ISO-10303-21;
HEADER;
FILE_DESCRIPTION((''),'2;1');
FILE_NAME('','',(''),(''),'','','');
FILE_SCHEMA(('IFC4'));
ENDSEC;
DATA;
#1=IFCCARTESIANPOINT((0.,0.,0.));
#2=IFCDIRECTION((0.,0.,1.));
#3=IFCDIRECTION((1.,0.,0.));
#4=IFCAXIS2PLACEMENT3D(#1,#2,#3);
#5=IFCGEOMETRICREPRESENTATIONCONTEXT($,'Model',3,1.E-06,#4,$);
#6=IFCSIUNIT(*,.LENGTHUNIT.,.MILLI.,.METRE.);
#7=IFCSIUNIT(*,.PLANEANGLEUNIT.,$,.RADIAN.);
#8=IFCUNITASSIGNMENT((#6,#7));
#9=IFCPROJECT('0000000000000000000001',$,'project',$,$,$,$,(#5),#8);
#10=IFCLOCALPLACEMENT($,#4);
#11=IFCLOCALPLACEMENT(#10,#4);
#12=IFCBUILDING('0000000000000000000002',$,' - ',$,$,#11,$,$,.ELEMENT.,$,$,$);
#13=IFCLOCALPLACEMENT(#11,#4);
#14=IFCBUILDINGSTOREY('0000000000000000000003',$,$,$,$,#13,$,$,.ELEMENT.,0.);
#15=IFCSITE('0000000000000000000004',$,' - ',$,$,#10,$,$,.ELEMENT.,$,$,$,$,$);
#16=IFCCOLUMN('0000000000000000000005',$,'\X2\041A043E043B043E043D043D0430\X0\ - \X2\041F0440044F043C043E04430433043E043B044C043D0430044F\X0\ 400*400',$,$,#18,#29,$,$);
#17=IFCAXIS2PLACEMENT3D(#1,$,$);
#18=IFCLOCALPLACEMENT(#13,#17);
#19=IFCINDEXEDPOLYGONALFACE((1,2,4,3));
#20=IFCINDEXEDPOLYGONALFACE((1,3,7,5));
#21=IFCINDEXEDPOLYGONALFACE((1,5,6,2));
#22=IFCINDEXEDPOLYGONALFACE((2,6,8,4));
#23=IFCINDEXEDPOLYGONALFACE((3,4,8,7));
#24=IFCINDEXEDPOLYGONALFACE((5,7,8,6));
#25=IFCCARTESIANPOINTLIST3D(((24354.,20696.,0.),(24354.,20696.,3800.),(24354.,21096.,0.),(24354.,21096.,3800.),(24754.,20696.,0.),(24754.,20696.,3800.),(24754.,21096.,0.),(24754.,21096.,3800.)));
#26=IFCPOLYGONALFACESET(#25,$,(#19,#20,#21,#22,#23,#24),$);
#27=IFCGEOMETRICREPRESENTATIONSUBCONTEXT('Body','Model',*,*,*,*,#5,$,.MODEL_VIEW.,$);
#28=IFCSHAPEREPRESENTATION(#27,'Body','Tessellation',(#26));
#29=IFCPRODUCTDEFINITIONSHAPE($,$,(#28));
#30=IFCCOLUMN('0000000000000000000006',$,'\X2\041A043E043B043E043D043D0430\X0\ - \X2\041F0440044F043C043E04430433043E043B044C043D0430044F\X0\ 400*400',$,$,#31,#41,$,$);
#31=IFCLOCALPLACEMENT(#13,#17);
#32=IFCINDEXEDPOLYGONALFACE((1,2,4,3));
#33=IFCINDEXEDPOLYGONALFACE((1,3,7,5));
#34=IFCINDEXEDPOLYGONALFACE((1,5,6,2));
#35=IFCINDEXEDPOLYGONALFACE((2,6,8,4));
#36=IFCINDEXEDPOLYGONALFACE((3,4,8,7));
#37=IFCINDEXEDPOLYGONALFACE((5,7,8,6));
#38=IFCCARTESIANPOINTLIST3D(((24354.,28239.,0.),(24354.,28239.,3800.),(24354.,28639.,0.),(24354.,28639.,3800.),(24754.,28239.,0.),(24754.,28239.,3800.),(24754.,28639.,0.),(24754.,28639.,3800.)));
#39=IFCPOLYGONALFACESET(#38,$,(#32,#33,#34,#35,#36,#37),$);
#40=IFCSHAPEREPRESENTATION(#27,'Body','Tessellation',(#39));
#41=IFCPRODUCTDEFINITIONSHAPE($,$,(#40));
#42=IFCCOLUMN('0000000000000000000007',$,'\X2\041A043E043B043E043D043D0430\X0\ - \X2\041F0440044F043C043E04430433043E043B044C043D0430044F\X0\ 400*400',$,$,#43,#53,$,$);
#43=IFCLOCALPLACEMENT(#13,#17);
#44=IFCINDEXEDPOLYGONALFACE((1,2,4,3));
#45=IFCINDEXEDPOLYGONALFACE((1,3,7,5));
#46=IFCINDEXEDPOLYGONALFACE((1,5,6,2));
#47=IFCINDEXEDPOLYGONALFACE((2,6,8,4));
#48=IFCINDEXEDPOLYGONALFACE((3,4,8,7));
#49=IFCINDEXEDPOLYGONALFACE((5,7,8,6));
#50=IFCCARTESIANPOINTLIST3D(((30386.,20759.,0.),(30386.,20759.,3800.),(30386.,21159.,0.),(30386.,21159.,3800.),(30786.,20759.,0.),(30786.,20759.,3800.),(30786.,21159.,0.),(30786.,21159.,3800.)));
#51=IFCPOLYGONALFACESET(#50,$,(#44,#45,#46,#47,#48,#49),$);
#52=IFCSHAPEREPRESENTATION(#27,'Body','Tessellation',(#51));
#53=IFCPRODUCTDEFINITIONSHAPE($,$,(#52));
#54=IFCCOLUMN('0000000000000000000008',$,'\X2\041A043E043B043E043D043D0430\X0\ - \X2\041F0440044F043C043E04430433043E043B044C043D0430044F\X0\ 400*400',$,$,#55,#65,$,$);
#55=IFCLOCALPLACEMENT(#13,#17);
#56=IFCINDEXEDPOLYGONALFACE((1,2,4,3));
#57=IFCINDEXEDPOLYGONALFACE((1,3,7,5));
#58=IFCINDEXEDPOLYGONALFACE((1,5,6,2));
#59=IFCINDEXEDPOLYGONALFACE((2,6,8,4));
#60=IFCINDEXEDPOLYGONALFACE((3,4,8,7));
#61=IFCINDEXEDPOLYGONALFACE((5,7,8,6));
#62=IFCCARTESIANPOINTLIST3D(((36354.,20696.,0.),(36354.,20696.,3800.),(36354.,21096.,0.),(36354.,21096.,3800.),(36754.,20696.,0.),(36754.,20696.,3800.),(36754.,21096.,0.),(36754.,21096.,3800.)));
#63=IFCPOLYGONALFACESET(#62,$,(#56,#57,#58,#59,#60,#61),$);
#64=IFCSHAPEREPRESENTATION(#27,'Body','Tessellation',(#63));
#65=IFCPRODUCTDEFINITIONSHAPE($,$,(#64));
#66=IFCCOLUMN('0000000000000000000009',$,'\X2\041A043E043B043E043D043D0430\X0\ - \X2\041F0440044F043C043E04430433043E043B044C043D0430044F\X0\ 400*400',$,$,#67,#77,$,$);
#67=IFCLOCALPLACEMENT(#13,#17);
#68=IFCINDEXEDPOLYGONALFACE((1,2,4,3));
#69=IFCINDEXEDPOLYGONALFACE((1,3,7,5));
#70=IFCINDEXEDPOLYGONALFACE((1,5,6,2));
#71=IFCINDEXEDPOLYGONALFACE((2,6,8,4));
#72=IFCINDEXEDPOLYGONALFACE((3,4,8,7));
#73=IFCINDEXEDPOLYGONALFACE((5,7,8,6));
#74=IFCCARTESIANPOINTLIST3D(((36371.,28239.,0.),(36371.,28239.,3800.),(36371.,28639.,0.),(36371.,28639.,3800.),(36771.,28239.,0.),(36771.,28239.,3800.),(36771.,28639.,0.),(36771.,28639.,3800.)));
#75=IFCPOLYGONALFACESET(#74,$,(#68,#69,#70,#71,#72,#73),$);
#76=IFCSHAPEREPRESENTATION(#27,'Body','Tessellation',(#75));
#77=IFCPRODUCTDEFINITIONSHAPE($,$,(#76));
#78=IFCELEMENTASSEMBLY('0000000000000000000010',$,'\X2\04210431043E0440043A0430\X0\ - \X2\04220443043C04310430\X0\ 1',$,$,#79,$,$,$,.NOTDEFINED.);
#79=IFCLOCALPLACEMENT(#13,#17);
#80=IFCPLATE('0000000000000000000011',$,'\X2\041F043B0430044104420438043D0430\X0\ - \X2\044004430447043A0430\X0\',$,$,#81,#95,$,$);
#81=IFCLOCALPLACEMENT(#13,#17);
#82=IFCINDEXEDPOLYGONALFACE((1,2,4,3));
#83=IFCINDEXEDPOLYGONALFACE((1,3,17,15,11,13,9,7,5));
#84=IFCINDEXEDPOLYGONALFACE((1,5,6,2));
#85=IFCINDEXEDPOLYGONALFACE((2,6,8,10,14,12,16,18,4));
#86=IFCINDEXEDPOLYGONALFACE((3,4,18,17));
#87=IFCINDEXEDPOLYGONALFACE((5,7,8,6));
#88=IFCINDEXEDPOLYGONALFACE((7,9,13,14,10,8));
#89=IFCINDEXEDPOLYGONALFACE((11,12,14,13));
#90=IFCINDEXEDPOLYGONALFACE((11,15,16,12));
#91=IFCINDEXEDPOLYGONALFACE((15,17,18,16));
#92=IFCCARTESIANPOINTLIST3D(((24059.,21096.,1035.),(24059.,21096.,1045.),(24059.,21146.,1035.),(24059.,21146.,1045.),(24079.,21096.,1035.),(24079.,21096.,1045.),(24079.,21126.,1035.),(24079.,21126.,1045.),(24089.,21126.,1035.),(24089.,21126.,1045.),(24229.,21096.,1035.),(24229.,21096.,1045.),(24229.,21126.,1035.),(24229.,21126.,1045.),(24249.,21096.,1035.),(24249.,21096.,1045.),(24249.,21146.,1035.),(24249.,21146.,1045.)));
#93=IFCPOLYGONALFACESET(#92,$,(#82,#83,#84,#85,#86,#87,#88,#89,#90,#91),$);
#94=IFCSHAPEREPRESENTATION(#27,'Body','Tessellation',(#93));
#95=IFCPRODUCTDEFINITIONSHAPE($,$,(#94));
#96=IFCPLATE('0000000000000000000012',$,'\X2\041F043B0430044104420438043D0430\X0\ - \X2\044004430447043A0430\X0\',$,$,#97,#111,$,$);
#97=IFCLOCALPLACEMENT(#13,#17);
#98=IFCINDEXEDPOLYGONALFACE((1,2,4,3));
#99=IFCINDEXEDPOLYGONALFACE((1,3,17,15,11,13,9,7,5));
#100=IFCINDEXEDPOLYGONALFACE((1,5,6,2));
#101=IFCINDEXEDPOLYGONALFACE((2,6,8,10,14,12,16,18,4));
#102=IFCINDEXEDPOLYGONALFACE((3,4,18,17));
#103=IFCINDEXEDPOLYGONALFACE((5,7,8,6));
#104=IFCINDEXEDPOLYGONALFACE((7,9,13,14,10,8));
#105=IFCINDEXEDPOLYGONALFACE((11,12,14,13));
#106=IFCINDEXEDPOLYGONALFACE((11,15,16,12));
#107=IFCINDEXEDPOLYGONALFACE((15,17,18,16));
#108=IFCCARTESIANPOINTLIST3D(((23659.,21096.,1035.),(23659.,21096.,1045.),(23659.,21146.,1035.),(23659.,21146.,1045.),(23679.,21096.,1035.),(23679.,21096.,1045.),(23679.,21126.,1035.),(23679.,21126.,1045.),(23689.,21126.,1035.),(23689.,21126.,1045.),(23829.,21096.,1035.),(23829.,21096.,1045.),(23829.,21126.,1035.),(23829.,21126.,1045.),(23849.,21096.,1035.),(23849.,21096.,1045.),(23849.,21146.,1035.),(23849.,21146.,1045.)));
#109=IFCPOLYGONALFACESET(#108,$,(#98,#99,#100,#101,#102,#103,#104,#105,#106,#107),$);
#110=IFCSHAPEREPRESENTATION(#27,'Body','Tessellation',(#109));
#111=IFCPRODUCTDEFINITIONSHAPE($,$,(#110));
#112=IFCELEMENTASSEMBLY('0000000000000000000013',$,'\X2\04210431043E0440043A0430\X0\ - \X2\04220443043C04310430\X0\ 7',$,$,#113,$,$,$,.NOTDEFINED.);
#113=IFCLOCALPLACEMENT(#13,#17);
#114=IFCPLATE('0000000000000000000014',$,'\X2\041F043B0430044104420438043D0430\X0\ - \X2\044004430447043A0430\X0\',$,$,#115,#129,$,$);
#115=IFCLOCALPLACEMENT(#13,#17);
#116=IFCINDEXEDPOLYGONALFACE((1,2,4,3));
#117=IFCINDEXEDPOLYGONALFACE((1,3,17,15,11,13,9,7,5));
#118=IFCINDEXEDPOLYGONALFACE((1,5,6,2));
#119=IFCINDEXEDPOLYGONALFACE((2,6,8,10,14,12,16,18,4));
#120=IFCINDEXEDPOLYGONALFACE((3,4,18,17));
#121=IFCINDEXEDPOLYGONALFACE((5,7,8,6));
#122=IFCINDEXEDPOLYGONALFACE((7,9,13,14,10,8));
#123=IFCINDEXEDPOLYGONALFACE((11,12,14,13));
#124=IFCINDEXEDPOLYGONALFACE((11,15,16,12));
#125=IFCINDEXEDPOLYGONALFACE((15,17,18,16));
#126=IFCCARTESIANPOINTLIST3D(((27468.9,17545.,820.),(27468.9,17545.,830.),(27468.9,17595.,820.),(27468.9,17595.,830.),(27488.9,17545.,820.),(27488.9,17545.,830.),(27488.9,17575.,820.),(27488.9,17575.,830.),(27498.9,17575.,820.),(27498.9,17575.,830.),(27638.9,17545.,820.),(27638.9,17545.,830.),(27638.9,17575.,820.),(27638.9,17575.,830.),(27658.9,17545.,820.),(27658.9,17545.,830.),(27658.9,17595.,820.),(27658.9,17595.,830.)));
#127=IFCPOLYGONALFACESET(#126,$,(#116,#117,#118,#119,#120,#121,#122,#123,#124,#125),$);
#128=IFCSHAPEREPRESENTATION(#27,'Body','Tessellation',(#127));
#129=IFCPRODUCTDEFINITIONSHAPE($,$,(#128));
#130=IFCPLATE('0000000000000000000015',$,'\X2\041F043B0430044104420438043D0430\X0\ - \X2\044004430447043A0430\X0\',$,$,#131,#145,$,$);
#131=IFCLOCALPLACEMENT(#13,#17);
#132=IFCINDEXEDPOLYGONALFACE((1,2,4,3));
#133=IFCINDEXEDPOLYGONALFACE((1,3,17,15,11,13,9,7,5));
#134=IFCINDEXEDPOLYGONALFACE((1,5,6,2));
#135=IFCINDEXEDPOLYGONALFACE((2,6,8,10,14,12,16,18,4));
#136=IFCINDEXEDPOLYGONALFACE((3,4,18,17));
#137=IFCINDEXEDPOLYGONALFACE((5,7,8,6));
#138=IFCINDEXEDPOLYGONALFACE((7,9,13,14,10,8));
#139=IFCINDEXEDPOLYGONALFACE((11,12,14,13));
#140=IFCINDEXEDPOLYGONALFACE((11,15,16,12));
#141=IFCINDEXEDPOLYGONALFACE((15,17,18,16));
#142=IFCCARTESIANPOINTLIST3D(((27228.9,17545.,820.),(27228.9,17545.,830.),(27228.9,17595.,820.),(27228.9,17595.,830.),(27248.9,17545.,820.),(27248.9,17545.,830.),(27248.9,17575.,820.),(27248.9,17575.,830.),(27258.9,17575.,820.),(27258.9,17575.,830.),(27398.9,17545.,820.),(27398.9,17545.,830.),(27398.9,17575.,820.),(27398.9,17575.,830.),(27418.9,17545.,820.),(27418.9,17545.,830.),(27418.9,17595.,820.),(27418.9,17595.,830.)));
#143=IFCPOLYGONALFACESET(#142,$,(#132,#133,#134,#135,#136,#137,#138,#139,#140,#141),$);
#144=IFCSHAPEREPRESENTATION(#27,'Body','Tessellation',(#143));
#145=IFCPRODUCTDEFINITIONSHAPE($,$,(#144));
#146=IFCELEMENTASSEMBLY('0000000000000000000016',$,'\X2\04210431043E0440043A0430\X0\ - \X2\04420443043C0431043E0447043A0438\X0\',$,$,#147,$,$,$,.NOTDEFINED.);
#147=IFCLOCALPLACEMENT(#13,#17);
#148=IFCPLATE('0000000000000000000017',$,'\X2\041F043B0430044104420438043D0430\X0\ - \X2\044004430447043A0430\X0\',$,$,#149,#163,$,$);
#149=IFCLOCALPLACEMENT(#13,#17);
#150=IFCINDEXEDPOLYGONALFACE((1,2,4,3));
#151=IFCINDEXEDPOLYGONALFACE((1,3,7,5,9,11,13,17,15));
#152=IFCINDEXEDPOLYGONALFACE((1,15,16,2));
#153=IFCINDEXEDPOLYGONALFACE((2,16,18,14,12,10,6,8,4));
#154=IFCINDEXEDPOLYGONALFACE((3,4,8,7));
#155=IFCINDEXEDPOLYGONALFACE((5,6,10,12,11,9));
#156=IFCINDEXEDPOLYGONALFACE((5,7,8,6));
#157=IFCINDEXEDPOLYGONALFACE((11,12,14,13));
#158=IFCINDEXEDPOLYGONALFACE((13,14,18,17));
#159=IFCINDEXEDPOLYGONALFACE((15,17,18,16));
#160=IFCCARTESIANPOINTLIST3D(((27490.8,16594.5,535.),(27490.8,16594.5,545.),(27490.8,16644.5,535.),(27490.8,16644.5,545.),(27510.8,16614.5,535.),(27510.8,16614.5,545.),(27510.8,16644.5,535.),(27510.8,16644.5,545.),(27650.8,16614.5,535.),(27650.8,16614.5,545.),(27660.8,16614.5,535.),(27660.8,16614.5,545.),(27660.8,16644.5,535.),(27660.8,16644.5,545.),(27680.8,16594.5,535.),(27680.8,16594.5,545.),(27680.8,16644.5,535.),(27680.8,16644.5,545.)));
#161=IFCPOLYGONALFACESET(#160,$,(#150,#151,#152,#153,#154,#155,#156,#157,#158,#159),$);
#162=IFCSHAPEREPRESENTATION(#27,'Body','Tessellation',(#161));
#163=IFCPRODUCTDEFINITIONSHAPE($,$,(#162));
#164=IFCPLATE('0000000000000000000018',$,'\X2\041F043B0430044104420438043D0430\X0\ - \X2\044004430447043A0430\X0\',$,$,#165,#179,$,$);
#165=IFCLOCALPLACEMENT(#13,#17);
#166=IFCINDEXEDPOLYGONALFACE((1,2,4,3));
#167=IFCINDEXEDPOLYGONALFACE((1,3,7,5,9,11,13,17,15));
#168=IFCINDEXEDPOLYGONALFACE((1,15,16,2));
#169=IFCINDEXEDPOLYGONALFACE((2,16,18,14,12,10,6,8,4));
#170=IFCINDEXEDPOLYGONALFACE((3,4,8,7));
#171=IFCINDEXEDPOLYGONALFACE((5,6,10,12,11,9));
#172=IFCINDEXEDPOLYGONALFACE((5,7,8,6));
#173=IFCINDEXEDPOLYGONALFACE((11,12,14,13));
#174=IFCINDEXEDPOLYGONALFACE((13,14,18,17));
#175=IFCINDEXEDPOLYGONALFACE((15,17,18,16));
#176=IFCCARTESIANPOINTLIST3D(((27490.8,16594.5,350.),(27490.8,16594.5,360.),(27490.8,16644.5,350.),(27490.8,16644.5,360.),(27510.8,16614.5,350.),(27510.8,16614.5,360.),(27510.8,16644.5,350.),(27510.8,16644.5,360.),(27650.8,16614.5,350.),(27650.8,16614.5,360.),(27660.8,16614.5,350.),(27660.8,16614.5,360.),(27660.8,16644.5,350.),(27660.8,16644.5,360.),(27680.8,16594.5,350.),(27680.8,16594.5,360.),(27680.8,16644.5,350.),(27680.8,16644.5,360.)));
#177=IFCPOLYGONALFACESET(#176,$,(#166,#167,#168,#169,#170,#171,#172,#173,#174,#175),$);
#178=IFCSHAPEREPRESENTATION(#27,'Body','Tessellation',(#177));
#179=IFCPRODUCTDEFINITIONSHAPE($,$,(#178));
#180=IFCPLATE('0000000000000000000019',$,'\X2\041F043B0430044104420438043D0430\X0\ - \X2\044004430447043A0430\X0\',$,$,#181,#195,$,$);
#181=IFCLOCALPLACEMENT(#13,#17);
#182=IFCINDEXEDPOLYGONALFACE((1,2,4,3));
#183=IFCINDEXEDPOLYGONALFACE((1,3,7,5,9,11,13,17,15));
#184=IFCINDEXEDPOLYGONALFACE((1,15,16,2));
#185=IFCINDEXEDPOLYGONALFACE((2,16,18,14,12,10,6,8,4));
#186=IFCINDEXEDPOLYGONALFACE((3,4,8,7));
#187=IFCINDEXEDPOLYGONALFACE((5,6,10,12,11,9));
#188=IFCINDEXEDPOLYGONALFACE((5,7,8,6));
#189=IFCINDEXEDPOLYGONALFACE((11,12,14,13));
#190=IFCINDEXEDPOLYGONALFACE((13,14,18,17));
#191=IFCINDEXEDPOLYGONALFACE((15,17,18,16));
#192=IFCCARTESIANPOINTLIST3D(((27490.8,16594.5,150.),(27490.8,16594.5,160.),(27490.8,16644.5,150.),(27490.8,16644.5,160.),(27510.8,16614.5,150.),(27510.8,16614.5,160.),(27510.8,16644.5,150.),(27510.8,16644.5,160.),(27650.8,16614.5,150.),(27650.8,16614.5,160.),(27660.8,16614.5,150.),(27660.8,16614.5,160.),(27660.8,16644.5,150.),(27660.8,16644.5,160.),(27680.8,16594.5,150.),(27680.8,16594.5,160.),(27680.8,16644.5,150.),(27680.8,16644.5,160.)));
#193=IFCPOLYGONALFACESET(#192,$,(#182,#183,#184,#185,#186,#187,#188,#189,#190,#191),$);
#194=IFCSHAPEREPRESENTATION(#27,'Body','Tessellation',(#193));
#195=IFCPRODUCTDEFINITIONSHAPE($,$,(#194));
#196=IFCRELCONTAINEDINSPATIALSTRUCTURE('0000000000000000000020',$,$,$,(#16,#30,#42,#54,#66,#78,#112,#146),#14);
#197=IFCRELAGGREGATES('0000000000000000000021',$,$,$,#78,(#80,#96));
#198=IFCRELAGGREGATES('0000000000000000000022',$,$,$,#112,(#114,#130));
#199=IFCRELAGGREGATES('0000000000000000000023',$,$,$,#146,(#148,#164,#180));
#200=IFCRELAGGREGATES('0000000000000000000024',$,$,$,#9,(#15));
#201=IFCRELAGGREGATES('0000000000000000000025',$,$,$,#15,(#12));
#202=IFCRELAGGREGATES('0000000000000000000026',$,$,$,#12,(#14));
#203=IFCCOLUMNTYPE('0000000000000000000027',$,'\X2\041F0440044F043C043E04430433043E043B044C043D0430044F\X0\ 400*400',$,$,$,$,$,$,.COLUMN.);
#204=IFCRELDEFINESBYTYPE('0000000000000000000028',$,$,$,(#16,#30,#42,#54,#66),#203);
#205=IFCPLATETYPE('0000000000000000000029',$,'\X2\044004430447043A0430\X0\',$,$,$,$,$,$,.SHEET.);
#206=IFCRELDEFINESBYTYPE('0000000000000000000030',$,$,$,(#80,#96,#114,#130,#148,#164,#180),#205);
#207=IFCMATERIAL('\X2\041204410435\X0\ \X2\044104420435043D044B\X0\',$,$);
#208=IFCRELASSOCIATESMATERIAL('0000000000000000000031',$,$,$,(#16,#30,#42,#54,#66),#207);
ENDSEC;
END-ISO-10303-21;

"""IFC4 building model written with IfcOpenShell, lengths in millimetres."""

from ifc_helpers import new_model, si_unit, frame, origin_with_axes, place, context, subcontext, project, spatial, line, indexed_curve, outline, extrude, source, transform, mapped, material, type_object, element, aggregate, save


model = new_model("IFC4")

# Units and contexts
model_context = context("Model", 3, precision=1e-06, world=origin_with_axes())
body_context = subcontext(model_context, "Body", "Model", "MODEL_VIEW")
ifc_project = project(units=[si_unit("LENGTHUNIT", "METRE", prefix="MILLI"), si_unit("PLANEANGLEUNIT", "RADIAN")], contexts=[model_context])

# Site, building, storey
site_placement = place(None, origin_with_axes())
site = spatial("IfcSite", under=ifc_project, at=site_placement, Name=" - ", CompositionType="ELEMENT")
building_placement = place(site_placement, origin_with_axes())
building = spatial("IfcBuilding", under=site, at=building_placement, Name=" - ", CompositionType="ELEMENT")
storey_placement = place(building_placement, origin_with_axes())
storey = spatial("IfcBuildingStorey", under=building, at=storey_placement, CompositionType="ELEMENT", Elevation=0.0)

# Columns
ifc_material = material(Name="Все стены")
column_type = type_object("IfcColumnType", Name="Прямоугольная 400*400", PredefinedType="COLUMN")
shared_shape_1 = source(origin_with_axes(), body_context, "Body", "SweptSolid", [
    extrude(outline(indexed_curve([(-200.0, -200.0), (200.0, -200.0), (200.0, 200.0), (-200.0, 200.0)], segments=[line(1, 2), line(2, 3), line(3, 4), line(4, 1)])), origin_with_axes(), (0.0, 0.0, 1.0), 3800.0),
])
for number, where, z_axis, x_axis, name in (
    (1, (24554.0, 20896.0, 0.0), (0.0, 0.0, 1.0), (1.0, 0.0, 0.0), "Колонна - Прямоугольная 400*400"),
    (2, (24554.0, 28439.0, 0.0), (0.0, 0.0, 1.0), (1.0, 0.0, 0.0), "Колонна - Прямоугольная 400*400"),
    (3, (30586.0, 20959.0, 0.0), (0.0, 0.0, 1.0), (1.0, 0.0, 0.0), "Колонна - Прямоугольная 400*400"),
    (4, (36554.0, 20896.0, 0.0), (0.0, 0.0, 1.0), (1.0, 0.0, 0.0), "Колонна - Прямоугольная 400*400"),
    (5, (36571.0, 28439.0, 0.0), (0.0, 0.0, 1.0), (1.0, 0.0, 0.0), "Колонна - Прямоугольная 400*400"),
):
    element("IfcColumn", number, at=place(storey_placement, frame(where, z_axis=z_axis, x_axis=x_axis)), inside=storey, type_object=column_type, material=ifc_material, Name=name, context=body_context, shape_type="MappedRepresentation", body=[
        mapped(shared_shape_1, transform((0.0, 0.0, 0.0), x_axis=(1.0, 0.0, 0.0), y_axis=(0.0, 1.0, 0.0), z_axis=(0.0, 0.0, 1.0), scale=1.0)),
    ])

# Element assemblies, plates
assembly_1_placement = place(storey_placement, frame((24354.0, 21081.0, 0.0), z_axis=(0.0, 0.0, 1.0), x_axis=(-1.0, 0.0, 0.0)))
assembly_1 = element("IfcElementAssembly", 6, at=assembly_1_placement, inside=storey, Name="Сборка - Тумба 1", PredefinedType="NOTDEFINED")
plate_type = type_object("IfcPlateType", Name="ручка", PredefinedType="SHEET")
shared_shape_2 = source(origin_with_axes(), body_context, "Body", "SweptSolid", [
    extrude(outline(indexed_curve([(-95.0, -25.0), (-75.0, -25.0), (-75.0, 5.0), (-65.0, 5.0), (75.0, 5.0), (75.0, -25.0), (95.0, -25.0), (95.0, 25.0), (-95.0, 25.0)], segments=[line(1, 2), line(2, 3), line(3, 4), line(4, 5), line(5, 6), line(6, 7), line(7, 8), line(8, 9), line(9, 1)])), origin_with_axes(), (0.0, 0.0, 1.0), 10.0),
])
plate_1_placement = place(assembly_1_placement, frame((200.0, -40.0, 1035.0), z_axis=(0.0, 0.0, 1.0), x_axis=(-1.0, 0.0, 0.0)))
plate_1 = element("IfcPlate", 7, at=plate_1_placement, type_object=plate_type, Name="Пластина - ручка", context=body_context, shape_type="MappedRepresentation", body=[
    mapped(shared_shape_2, transform((0.0, 0.0, 0.0), x_axis=(1.0, 0.0, 0.0), y_axis=(0.0, 1.0, 0.0), z_axis=(0.0, 0.0, 1.0), scale=1.0)),
])
plate_2_placement = place(assembly_1_placement, frame((600.0, -40.0, 1035.0), z_axis=(0.0, 0.0, 1.0), x_axis=(-1.0, 0.0, 0.0)))
plate_2 = element("IfcPlate", 8, at=plate_2_placement, type_object=plate_type, Name="Пластина - ручка", context=body_context, shape_type="MappedRepresentation", body=[
    mapped(shared_shape_2, transform((0.0, 0.0, 0.0), x_axis=(1.0, 0.0, 0.0), y_axis=(0.0, 1.0, 0.0), z_axis=(0.0, 0.0, 1.0), scale=1.0)),
])
aggregate(assembly_1, [plate_1, plate_2])
assembly_2_placement = place(storey_placement, frame((27443.9, 17330.0, 0.0), z_axis=(0.0, 0.0, 1.0), x_axis=(-1.0, 0.0, 0.0)))
assembly_2 = element("IfcElementAssembly", 9, at=assembly_2_placement, inside=storey, Name="Сборка - Тумба 7", PredefinedType="NOTDEFINED")
plate_3_placement = place(assembly_2_placement, frame((-120.0, -240.0, 820.0), z_axis=(0.0, 0.0, 1.0), x_axis=(-1.0, 0.0, 0.0)))
plate_3 = element("IfcPlate", 10, at=plate_3_placement, type_object=plate_type, Name="Пластина - ручка", context=body_context, shape_type="MappedRepresentation", body=[
    mapped(shared_shape_2, transform((0.0, 0.0, 0.0), x_axis=(1.0, 0.0, 0.0), y_axis=(0.0, 1.0, 0.0), z_axis=(0.0, 0.0, 1.0), scale=1.0)),
])
plate_4_placement = place(assembly_2_placement, frame((120.0, -240.0, 820.0), z_axis=(0.0, 0.0, 1.0), x_axis=(-1.0, 0.0, 0.0)))
plate_4 = element("IfcPlate", 11, at=plate_4_placement, type_object=plate_type, Name="Пластина - ручка", context=body_context, shape_type="MappedRepresentation", body=[
    mapped(shared_shape_2, transform((0.0, 0.0, 0.0), x_axis=(1.0, 0.0, 0.0), y_axis=(0.0, 1.0, 0.0), z_axis=(0.0, 0.0, 1.0), scale=1.0)),
])
aggregate(assembly_2, [plate_3, plate_4])
assembly_3_placement = place(storey_placement, frame((27385.8, 16644.5, 0.0), z_axis=(0.0, 0.0, 1.0), x_axis=(1.0, 0.0, 0.0)))
assembly_3 = element("IfcElementAssembly", 12, at=assembly_3_placement, inside=storey, Name="Сборка - тумбочки", PredefinedType="NOTDEFINED")
plate_5_placement = place(assembly_3_placement, frame((200.0, -25.0, 535.0), z_axis=(0.0, 0.0, 1.0), x_axis=(-1.0, 0.0, 0.0)))
plate_5 = element("IfcPlate", 13, at=plate_5_placement, type_object=plate_type, Name="Пластина - ручка", context=body_context, shape_type="MappedRepresentation", body=[
    mapped(shared_shape_2, transform((0.0, 0.0, 0.0), x_axis=(1.0, 0.0, 0.0), y_axis=(0.0, 1.0, 0.0), z_axis=(0.0, 0.0, 1.0), scale=1.0)),
])
plate_6_placement = place(assembly_3_placement, frame((200.0, -25.0, 350.0), z_axis=(0.0, 0.0, 1.0), x_axis=(-1.0, 0.0, 0.0)))
plate_6 = element("IfcPlate", 14, at=plate_6_placement, type_object=plate_type, Name="Пластина - ручка", context=body_context, shape_type="MappedRepresentation", body=[
    mapped(shared_shape_2, transform((0.0, 0.0, 0.0), x_axis=(1.0, 0.0, 0.0), y_axis=(0.0, 1.0, 0.0), z_axis=(0.0, 0.0, 1.0), scale=1.0)),
])
plate_7_placement = place(assembly_3_placement, frame((200.0, -25.0, 150.0), z_axis=(0.0, 0.0, 1.0), x_axis=(-1.0, 0.0, 0.0)))
plate_7 = element("IfcPlate", 15, at=plate_7_placement, type_object=plate_type, Name="Пластина - ручка", context=body_context, shape_type="MappedRepresentation", body=[
    mapped(shared_shape_2, transform((0.0, 0.0, 0.0), x_axis=(1.0, 0.0, 0.0), y_axis=(0.0, 1.0, 0.0), z_axis=(0.0, 0.0, 1.0), scale=1.0)),
])
aggregate(assembly_3, [plate_5, plate_6, plate_7])

save(model, "model.ifc")
